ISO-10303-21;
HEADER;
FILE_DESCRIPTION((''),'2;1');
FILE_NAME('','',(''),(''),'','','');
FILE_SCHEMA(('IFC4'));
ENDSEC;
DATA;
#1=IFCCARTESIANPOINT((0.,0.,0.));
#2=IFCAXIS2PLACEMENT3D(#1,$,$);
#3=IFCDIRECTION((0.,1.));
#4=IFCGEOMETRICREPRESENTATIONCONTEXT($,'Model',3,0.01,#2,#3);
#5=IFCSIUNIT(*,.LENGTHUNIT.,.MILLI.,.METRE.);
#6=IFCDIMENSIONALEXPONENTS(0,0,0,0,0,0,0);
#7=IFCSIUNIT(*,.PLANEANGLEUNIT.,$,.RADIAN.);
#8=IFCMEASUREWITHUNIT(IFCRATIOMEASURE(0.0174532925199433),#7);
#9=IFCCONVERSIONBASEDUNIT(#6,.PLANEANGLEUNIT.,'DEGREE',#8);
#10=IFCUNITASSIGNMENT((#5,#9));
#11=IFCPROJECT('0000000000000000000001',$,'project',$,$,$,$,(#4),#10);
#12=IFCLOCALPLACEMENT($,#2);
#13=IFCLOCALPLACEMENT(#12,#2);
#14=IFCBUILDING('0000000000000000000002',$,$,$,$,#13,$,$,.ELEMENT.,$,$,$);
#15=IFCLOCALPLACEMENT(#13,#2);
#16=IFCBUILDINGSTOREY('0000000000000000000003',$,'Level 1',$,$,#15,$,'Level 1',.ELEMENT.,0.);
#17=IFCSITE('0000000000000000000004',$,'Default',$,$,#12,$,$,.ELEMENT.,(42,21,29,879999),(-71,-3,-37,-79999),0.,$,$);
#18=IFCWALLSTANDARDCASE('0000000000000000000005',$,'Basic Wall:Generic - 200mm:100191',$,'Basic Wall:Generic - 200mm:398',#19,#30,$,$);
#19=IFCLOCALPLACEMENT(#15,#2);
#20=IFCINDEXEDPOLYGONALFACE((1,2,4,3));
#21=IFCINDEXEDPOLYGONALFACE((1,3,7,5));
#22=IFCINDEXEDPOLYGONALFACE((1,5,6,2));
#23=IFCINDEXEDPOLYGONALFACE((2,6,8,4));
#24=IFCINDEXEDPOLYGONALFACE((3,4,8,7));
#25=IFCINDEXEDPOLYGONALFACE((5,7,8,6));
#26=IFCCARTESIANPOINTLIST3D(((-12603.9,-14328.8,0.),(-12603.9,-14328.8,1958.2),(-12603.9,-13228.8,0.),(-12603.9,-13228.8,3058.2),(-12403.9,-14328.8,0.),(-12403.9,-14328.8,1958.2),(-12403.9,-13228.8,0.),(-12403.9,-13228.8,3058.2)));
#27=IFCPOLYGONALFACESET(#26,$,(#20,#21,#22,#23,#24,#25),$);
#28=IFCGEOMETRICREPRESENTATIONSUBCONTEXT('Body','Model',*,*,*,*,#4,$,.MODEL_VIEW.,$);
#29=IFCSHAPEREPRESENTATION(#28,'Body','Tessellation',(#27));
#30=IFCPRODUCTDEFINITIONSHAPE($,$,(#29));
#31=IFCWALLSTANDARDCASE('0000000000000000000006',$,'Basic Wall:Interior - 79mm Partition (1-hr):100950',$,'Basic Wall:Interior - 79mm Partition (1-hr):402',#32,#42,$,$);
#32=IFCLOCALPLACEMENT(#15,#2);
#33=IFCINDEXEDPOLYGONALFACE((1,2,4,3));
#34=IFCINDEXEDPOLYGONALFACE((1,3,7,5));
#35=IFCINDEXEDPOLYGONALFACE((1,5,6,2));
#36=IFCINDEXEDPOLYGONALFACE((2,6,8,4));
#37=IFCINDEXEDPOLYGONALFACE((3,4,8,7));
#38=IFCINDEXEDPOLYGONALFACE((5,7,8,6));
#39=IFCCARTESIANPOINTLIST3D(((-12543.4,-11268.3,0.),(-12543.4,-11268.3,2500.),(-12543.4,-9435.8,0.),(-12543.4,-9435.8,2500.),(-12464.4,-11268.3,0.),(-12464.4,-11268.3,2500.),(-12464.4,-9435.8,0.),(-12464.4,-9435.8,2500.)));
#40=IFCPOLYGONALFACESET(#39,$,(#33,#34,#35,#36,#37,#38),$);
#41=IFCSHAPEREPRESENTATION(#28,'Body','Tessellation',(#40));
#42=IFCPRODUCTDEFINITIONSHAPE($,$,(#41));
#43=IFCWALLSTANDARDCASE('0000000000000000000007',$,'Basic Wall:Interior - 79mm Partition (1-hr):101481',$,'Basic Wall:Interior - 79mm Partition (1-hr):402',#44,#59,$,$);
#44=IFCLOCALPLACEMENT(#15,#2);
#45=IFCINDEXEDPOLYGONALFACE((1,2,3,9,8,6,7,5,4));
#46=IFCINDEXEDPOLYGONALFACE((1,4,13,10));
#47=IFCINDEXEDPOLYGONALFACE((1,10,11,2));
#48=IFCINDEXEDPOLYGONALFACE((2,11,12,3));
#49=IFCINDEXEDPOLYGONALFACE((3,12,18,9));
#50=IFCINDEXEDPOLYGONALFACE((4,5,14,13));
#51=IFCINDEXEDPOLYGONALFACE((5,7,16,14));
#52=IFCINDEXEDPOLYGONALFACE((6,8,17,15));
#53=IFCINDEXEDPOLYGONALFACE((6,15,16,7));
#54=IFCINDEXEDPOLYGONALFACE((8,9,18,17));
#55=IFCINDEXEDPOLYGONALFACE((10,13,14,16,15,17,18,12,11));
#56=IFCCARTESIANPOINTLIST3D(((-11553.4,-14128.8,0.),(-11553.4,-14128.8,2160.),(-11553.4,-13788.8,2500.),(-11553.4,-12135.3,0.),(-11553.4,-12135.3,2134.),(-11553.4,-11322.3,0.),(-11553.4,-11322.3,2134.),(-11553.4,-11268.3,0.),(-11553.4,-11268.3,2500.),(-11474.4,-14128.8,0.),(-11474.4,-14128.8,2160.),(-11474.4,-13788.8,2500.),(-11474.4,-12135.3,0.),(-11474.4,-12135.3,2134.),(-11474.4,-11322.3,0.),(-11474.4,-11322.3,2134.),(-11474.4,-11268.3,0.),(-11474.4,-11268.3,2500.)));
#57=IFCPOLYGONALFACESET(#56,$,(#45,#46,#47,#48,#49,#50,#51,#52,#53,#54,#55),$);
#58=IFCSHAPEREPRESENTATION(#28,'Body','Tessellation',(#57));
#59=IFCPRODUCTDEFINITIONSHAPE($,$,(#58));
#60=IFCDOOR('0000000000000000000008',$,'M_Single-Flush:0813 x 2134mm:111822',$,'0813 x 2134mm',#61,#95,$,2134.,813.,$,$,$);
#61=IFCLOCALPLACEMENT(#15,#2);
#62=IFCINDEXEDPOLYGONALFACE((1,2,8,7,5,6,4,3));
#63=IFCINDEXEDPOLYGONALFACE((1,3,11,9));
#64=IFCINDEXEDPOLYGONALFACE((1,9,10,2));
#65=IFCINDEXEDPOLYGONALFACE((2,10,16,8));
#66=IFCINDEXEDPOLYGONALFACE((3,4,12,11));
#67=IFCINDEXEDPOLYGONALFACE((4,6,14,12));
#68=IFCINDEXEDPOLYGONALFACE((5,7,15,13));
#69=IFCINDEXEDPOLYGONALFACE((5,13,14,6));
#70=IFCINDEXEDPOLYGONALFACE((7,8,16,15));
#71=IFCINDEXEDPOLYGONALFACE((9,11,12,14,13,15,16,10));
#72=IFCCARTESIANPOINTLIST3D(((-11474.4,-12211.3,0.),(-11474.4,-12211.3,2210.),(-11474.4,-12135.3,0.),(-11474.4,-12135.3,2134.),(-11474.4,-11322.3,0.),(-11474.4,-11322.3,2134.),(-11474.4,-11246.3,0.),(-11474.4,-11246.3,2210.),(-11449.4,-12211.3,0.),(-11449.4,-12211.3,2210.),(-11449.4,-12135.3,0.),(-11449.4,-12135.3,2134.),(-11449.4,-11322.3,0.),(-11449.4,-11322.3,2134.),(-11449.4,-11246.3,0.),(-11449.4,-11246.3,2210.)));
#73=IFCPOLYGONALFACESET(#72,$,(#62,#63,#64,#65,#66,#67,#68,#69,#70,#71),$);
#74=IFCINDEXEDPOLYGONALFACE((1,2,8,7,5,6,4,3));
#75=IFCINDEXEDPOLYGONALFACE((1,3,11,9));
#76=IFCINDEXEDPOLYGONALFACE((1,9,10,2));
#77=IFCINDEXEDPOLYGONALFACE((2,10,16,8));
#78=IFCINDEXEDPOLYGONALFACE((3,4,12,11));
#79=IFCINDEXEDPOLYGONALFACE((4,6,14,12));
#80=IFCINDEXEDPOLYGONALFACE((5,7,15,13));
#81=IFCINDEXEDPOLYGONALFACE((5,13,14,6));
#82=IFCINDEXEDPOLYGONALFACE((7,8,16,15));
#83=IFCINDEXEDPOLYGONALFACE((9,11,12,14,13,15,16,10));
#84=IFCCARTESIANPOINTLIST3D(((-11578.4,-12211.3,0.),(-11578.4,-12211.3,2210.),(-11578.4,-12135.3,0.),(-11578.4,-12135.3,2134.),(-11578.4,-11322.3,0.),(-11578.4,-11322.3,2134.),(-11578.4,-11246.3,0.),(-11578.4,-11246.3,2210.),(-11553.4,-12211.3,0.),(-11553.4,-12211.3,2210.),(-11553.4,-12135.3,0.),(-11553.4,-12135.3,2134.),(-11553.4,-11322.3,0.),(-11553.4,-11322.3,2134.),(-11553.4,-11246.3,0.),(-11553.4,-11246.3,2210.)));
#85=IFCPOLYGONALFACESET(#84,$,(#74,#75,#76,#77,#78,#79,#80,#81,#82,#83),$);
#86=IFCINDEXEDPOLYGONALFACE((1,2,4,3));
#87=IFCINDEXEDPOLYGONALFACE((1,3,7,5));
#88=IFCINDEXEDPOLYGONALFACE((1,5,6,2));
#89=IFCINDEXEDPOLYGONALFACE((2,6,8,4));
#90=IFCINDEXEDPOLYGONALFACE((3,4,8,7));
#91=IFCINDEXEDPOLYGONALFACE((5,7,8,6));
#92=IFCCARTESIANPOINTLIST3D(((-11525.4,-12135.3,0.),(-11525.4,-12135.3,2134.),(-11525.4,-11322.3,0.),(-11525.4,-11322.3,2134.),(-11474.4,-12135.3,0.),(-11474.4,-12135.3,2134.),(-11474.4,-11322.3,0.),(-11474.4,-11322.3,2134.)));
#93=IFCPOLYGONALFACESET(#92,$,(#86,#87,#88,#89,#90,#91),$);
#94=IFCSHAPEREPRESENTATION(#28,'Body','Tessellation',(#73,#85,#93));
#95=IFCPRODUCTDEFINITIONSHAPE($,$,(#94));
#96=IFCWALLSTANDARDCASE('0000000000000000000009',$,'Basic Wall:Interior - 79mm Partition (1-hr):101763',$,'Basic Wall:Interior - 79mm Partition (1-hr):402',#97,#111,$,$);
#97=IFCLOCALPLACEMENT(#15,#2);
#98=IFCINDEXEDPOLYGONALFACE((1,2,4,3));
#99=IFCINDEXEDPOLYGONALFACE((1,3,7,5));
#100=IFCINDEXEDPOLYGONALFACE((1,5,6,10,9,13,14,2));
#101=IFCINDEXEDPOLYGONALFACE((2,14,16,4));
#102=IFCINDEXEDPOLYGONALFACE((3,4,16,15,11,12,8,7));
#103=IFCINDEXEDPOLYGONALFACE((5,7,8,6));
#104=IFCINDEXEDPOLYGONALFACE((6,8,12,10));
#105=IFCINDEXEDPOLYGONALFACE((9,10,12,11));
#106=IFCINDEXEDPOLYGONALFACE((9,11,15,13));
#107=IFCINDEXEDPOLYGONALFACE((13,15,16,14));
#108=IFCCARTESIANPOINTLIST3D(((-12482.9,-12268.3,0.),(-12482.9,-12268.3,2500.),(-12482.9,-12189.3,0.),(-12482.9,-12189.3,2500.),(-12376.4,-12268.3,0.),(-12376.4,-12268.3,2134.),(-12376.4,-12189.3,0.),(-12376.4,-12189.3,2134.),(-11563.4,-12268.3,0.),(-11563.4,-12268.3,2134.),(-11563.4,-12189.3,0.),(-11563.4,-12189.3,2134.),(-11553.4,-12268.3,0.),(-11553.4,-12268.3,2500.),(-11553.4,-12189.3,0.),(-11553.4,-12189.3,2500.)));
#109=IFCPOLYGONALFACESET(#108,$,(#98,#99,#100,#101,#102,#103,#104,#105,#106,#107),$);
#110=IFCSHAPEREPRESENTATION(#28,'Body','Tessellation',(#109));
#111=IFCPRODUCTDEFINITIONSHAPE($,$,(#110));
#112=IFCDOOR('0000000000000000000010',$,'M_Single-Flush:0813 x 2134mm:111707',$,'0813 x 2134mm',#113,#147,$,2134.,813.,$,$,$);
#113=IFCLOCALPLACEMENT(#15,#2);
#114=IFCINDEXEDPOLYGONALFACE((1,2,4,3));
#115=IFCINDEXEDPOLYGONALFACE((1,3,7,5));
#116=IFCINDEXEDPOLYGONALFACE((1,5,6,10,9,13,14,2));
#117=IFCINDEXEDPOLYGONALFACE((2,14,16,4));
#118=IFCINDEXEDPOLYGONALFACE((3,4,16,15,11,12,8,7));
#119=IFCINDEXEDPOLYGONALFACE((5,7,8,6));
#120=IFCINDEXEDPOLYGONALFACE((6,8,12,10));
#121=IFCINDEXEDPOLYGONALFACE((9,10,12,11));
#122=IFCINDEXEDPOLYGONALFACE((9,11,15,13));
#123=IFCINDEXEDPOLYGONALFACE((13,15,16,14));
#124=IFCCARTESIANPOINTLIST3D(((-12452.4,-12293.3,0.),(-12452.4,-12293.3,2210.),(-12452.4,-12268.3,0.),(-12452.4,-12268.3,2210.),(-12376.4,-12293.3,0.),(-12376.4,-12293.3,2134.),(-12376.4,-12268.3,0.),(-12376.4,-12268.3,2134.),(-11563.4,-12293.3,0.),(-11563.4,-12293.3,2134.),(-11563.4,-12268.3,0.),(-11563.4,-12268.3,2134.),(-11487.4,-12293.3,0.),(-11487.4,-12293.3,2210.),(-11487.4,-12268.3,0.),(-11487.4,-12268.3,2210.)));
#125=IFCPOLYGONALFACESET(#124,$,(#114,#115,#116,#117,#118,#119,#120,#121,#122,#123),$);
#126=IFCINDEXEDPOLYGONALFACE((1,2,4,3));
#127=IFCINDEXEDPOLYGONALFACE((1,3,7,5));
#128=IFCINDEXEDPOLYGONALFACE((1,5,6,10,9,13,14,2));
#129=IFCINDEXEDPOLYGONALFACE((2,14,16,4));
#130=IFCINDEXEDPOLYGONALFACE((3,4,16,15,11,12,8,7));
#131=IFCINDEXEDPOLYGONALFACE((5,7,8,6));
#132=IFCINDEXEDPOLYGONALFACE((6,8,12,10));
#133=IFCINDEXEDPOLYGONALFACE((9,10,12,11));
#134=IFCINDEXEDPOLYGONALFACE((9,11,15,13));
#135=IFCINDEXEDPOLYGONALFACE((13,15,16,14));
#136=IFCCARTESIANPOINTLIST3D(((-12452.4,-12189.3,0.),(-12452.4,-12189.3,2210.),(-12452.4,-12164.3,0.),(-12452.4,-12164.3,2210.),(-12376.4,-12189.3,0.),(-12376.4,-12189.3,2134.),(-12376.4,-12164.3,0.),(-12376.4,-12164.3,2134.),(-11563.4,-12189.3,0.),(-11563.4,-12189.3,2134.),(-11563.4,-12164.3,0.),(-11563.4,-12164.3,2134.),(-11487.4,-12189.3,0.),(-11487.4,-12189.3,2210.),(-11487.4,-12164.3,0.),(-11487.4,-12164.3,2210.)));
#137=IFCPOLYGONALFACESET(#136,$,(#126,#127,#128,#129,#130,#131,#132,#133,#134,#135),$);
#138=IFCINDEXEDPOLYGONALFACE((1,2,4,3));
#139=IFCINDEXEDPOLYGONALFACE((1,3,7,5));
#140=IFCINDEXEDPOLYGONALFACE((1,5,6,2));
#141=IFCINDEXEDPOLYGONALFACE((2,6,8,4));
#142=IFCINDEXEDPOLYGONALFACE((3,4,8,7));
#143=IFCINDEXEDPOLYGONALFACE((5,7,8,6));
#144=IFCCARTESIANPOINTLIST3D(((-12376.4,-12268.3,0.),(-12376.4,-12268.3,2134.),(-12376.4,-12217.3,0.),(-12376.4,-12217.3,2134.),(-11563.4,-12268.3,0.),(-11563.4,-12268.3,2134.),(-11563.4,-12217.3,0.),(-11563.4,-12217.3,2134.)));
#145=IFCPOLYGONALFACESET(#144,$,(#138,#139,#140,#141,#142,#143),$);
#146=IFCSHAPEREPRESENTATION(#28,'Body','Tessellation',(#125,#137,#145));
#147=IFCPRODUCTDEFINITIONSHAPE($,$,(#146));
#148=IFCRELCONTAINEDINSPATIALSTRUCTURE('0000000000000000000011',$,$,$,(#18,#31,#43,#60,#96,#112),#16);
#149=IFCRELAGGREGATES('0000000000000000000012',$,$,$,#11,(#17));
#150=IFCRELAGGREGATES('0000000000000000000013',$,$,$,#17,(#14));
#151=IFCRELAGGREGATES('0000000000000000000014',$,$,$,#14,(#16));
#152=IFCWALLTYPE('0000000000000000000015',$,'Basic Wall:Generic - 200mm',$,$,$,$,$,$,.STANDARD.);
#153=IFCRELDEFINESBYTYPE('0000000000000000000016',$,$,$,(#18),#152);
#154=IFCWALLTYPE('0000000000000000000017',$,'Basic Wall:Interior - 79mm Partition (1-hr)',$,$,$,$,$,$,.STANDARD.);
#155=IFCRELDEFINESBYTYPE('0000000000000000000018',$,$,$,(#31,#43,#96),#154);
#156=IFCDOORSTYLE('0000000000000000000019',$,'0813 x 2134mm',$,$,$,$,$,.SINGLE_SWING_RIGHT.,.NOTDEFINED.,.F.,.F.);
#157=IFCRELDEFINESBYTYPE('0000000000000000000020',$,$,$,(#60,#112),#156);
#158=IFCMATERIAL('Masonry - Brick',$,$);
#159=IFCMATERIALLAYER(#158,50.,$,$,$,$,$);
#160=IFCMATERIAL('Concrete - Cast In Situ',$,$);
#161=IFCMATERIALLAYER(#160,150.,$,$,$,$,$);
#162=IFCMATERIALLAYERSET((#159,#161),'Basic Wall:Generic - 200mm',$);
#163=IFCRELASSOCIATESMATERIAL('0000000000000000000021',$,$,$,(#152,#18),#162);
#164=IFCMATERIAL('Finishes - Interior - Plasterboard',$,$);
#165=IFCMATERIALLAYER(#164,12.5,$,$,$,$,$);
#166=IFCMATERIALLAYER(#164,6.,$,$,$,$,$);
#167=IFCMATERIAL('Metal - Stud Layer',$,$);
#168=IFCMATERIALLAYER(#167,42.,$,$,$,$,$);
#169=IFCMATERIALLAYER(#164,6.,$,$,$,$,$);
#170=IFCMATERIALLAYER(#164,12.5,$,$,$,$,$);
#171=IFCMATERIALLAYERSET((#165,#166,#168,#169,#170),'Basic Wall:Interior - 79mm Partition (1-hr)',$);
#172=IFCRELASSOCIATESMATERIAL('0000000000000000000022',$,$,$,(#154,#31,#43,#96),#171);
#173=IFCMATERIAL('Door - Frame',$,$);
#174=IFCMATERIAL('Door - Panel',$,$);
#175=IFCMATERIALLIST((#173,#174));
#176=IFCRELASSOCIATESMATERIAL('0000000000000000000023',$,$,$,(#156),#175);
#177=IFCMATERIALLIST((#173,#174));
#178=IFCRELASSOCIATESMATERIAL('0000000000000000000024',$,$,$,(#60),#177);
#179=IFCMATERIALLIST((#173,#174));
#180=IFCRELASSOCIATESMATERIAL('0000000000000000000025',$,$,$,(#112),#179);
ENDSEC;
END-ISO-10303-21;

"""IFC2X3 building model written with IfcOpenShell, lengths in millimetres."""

from ifc_helpers import new_model, entity, si_unit, converted_unit, direction, frame, frame_2d, origin, origin_2d_with_axis, place, context, subcontext, project, spatial, polyline, rectangle, outline, extrude, clip, halfspace, bounded_halfspace, source, transform, mapped, material, material_list, layer, layer_set, layer_usage, type_object, type_shapes, element, fill, save


model = new_model("IFC2X3")

# Units and contexts
model_context = context("Model", 3, precision=0.01, world=origin(), true_north=direction((0.0, 1.0)))
body_context = subcontext(model_context, "Body", "Model", "MODEL_VIEW")
ifc_project = project(units=[si_unit("LENGTHUNIT", "METRE", prefix="MILLI"), converted_unit("PLANEANGLEUNIT", "DEGREE", entity("IfcRatioMeasure", 0.0174532925199433), si_unit("PLANEANGLEUNIT", "RADIAN"), dimensions=[0, 0, 0, 0, 0, 0, 0])], contexts=[model_context])

# Site, building, storey
site_placement = place(None, origin())
site = spatial("IfcSite", under=ifc_project, at=site_placement, Name="Default", CompositionType="ELEMENT", RefLatitude=(42, 21, 29, 879999), RefLongitude=(-71, -3, -37, -79999), RefElevation=0.0)
building_placement = place(site_placement, origin())
building = spatial("IfcBuilding", under=site, at=building_placement, CompositionType="ELEMENT")
storey_placement = place(building_placement, origin())
storey = spatial("IfcBuildingStorey", under=building, at=storey_placement, Name="Level 1", LongName="Level 1", CompositionType="ELEMENT", Elevation=0.0)

# Wall
ifc_material_1 = material(Name="Masonry - Brick")
ifc_layer_1 = layer(ifc_material_1, 50.0)
ifc_material_2 = material(Name="Concrete - Cast In Situ")
ifc_layer_2 = layer(ifc_material_2, 150.0)
ifc_layer_set_1 = layer_set([ifc_layer_1, ifc_layer_2], Name="Basic Wall:Generic - 200mm")
ifc_layer_usage_1 = layer_usage(ifc_layer_set_1, "AXIS2", "NEGATIVE", 100.0)
wall_type_1 = type_object("IfcWallType", Name="Basic Wall:Generic - 200mm", PredefinedType="STANDARD", material=ifc_layer_set_1)
wall_1_placement = place(storey_placement, frame((-12503.9, -14328.8, 0.0), z_axis=(0.0, 0.0, 1.0), x_axis=(0.0, 1.0, 0.0)))
element("IfcWallStandardCase", 1, at=wall_1_placement, inside=storey, type_object=wall_type_1, material=ifc_layer_usage_1, Name="Basic Wall:Generic - 200mm:100191", ObjectType="Basic Wall:Generic - 200mm:398", context=body_context, shape_type="Clipping", body=[
    clip(extrude(rectangle(XDim=1100.0, YDim=200.0, at=frame_2d((550.0, 0.0), x_axis=(-1.0, 0.0))), origin(), (0.0, 0.0, 1.0), 3058.2), bounded_halfspace(frame((0.0, -100.0, 1958.2), z_axis=(0.707107, 0.0, -0.707107), x_axis=(0.0, 1.0, 0.0)), True, frame((0.0, -100.0, 1958.2)), polyline([(0.0, 0.0), (200.0, 0.0), (1100.0, 0.0), (1100.0, 200.0), (500.0, 200.0), (0.0, 200.0), (0.0, 0.0)]))),
])

# Shared definitions
ifc_material_3 = material(Name="Door - Frame")
ifc_material_4 = material(Name="Door - Panel")

# Wall
ifc_material_5 = material(Name="Finishes - Interior - Plasterboard")
ifc_layer_3 = layer(ifc_material_5, 12.5)
ifc_layer_4 = layer(ifc_material_5, 6.0)
ifc_material_6 = material(Name="Metal - Stud Layer")
ifc_layer_5 = layer(ifc_material_6, 42.0)
ifc_layer_6 = layer(ifc_material_5, 6.0)
ifc_layer_7 = layer(ifc_material_5, 12.5)
ifc_layer_set_2 = layer_set([ifc_layer_3, ifc_layer_4, ifc_layer_5, ifc_layer_6, ifc_layer_7], Name="Basic Wall:Interior - 79mm Partition (1-hr)")
ifc_layer_usage_2 = layer_usage(ifc_layer_set_2, "AXIS2", "NEGATIVE", 39.5)
wall_type_2 = type_object("IfcWallType", Name="Basic Wall:Interior - 79mm Partition (1-hr)", PredefinedType="STANDARD", material=ifc_layer_set_2)
wall_2_placement = place(storey_placement, frame((-12503.9, -11268.3, 0.0), z_axis=(0.0, 0.0, 1.0), x_axis=(0.0, 1.0, 0.0)))
element("IfcWallStandardCase", 2, at=wall_2_placement, inside=storey, type_object=wall_type_2, material=ifc_layer_usage_2, Name="Basic Wall:Interior - 79mm Partition (1-hr):100950", ObjectType="Basic Wall:Interior - 79mm Partition (1-hr):402", context=body_context, shape_type="SweptSolid", body=[
    extrude(rectangle(XDim=1832.5, YDim=79.0, at=frame_2d((916.3, 0.0), x_axis=(-1.0, 0.0))), origin(), (0.0, 0.0, 1.0), 2500.0),
])

# Walls, openings, doors
ifc_layer_usage_3 = layer_usage(ifc_layer_set_2, "AXIS2", "NEGATIVE", 39.5)
wall_3_placement = place(storey_placement, frame((-11513.9, -11268.3, 0.0), z_axis=(0.0, 0.0, 1.0), x_axis=(0.0, -1.0, 0.0)))
wall_3 = element("IfcWallStandardCase", 3, at=wall_3_placement, inside=storey, type_object=wall_type_2, material=ifc_layer_usage_3, Name="Basic Wall:Interior - 79mm Partition (1-hr):101481", ObjectType="Basic Wall:Interior - 79mm Partition (1-hr):402", context=body_context, shape_type="Clipping", body=[
    clip(extrude(rectangle(XDim=2860.5, YDim=79.0, at=frame_2d((1430.3, 0.0), x_axis=(-1.0, 0.0))), origin(), (0.0, 0.0, 1.0), 2500.0), halfspace(frame((2520.5, -39.5, 2500.0), z_axis=(0.707107, 0.0, 0.707107), x_axis=(0.0, 1.0, 0.0)), False)),
])
opening_1_placement = place(wall_3_placement, frame((54.0, -39.5, 0.0)))
opening_1 = element("IfcOpeningElement", 4, at=opening_1_placement, cuts=wall_3, ObjectType="Opening", context=body_context, shape_type="SweptSolid", body=[
    extrude(rectangle(XDim=813.0, YDim=2134.0, at=frame_2d((1067.0, 406.5), x_axis=(0.0, 1.0))), frame((0.0, 0.0, 0.0), z_axis=(0.0, 1.0, 0.0), x_axis=(0.0, 0.0, 1.0)), (0.0, 0.0, 1.0), 79.0),
])
ifc_material_list_1 = material_list([ifc_material_3, ifc_material_4])
ifc_material_list_2 = material_list([ifc_material_3, ifc_material_4])
door_style_1 = type_object("IfcDoorStyle", Name="0813 x 2134mm", ConstructionType="NOTDEFINED", OperationType="SINGLE_SWING_RIGHT", ParameterTakesPrecedence=False, Sizeable=False, material=ifc_material_list_2)
shared_shape_1 = source(origin(), body_context, "Body", "SweptSolid", [
    extrude(outline(polyline([(-482.5, -1124.0), (482.5, -1124.0), (482.5, 1086.0), (406.5, 1086.0), (406.5, -1048.0), (-406.5, -1048.0), (-406.5, 1086.0), (-482.5, 1086.0), (-482.5, -1124.0)])), frame((406.5, 79.0, 1086.0), z_axis=(0.0, 1.0, 0.0), x_axis=(1.0, 0.0, 0.0)), (0.0, 0.0, 1.0), 25.0),
    extrude(outline(polyline([(-1124.0, -482.5), (1086.0, -482.5), (1086.0, -406.5), (-1048.0, -406.5), (-1048.0, 406.5), (1086.0, 406.5), (1086.0, 482.5), (-1124.0, 482.5), (-1124.0, -482.5)])), frame((406.5, -25.0, 1086.0), z_axis=(0.0, 1.0, 0.0), x_axis=(0.0, 0.0, -1.0)), (0.0, 0.0, 1.0), 25.0),
    extrude(rectangle(XDim=51.0, YDim=813.0, at=origin_2d_with_axis()), frame((406.5, 53.5, 0.0), z_axis=(0.0, 0.0, 1.0), x_axis=(0.0, 1.0, 0.0)), (0.0, 0.0, 1.0), 2134.0),
])
type_shapes(door_style_1, [shared_shape_1])
door_1_placement = place(opening_1_placement, origin())
door_1 = element("IfcDoor", 5, at=door_1_placement, inside=storey, type_object=door_style_1, material=ifc_material_list_1, Name="M_Single-Flush:0813 x 2134mm:111822", ObjectType="0813 x 2134mm", OverallHeight=2134.0, OverallWidth=813.0, context=body_context, shape_type="MappedRepresentation", body=[
    mapped(shared_shape_1, transform((0.0, 0.0, 0.0), scale=1.0)),
])
fill(opening_1, door_1)
ifc_layer_usage_4 = layer_usage(ifc_layer_set_2, "AXIS2", "NEGATIVE", 39.5)
wall_4_placement = place(storey_placement, frame((-12482.9, -12228.8, 0.0)))
wall_4 = element("IfcWallStandardCase", 6, at=wall_4_placement, inside=storey, type_object=wall_type_2, material=ifc_layer_usage_4, Name="Basic Wall:Interior - 79mm Partition (1-hr):101763", ObjectType="Basic Wall:Interior - 79mm Partition (1-hr):402", context=body_context, shape_type="SweptSolid", body=[
    extrude(rectangle(XDim=929.5, YDim=79.0, at=frame_2d((464.8, 0.0), x_axis=(-1.0, 0.0))), origin(), (0.0, 0.0, 1.0), 2500.0),
])
opening_2_placement = place(wall_4_placement, frame((919.5, 39.5, 0.0)))
opening_2 = element("IfcOpeningElement", 7, at=opening_2_placement, cuts=wall_4, ObjectType="Opening", context=body_context, shape_type="SweptSolid", body=[
    extrude(rectangle(XDim=813.0, YDim=2134.0, at=frame_2d((1067.0, 406.5), x_axis=(0.0, 1.0))), frame((0.0, 0.0, 0.0), z_axis=(0.0, -1.0, 0.0), x_axis=(0.0, 0.0, 1.0)), (0.0, 0.0, 1.0), 79.0),
])
ifc_material_list_3 = material_list([ifc_material_3, ifc_material_4])
door_2_placement = place(opening_2_placement, frame((0.0, 0.0, 0.0), z_axis=(0.0, 0.0, 1.0), x_axis=(-1.0, 0.0, 0.0)))
door_2 = element("IfcDoor", 8, at=door_2_placement, inside=storey, type_object=door_style_1, material=ifc_material_list_3, Name="M_Single-Flush:0813 x 2134mm:111707", ObjectType="0813 x 2134mm", OverallHeight=2134.0, OverallWidth=813.0, context=body_context, shape_type="MappedRepresentation", body=[
    mapped(shared_shape_1, transform((0.0, 0.0, 0.0), scale=1.0)),
])
fill(opening_2, door_2)

save(model, "model.ifc")
